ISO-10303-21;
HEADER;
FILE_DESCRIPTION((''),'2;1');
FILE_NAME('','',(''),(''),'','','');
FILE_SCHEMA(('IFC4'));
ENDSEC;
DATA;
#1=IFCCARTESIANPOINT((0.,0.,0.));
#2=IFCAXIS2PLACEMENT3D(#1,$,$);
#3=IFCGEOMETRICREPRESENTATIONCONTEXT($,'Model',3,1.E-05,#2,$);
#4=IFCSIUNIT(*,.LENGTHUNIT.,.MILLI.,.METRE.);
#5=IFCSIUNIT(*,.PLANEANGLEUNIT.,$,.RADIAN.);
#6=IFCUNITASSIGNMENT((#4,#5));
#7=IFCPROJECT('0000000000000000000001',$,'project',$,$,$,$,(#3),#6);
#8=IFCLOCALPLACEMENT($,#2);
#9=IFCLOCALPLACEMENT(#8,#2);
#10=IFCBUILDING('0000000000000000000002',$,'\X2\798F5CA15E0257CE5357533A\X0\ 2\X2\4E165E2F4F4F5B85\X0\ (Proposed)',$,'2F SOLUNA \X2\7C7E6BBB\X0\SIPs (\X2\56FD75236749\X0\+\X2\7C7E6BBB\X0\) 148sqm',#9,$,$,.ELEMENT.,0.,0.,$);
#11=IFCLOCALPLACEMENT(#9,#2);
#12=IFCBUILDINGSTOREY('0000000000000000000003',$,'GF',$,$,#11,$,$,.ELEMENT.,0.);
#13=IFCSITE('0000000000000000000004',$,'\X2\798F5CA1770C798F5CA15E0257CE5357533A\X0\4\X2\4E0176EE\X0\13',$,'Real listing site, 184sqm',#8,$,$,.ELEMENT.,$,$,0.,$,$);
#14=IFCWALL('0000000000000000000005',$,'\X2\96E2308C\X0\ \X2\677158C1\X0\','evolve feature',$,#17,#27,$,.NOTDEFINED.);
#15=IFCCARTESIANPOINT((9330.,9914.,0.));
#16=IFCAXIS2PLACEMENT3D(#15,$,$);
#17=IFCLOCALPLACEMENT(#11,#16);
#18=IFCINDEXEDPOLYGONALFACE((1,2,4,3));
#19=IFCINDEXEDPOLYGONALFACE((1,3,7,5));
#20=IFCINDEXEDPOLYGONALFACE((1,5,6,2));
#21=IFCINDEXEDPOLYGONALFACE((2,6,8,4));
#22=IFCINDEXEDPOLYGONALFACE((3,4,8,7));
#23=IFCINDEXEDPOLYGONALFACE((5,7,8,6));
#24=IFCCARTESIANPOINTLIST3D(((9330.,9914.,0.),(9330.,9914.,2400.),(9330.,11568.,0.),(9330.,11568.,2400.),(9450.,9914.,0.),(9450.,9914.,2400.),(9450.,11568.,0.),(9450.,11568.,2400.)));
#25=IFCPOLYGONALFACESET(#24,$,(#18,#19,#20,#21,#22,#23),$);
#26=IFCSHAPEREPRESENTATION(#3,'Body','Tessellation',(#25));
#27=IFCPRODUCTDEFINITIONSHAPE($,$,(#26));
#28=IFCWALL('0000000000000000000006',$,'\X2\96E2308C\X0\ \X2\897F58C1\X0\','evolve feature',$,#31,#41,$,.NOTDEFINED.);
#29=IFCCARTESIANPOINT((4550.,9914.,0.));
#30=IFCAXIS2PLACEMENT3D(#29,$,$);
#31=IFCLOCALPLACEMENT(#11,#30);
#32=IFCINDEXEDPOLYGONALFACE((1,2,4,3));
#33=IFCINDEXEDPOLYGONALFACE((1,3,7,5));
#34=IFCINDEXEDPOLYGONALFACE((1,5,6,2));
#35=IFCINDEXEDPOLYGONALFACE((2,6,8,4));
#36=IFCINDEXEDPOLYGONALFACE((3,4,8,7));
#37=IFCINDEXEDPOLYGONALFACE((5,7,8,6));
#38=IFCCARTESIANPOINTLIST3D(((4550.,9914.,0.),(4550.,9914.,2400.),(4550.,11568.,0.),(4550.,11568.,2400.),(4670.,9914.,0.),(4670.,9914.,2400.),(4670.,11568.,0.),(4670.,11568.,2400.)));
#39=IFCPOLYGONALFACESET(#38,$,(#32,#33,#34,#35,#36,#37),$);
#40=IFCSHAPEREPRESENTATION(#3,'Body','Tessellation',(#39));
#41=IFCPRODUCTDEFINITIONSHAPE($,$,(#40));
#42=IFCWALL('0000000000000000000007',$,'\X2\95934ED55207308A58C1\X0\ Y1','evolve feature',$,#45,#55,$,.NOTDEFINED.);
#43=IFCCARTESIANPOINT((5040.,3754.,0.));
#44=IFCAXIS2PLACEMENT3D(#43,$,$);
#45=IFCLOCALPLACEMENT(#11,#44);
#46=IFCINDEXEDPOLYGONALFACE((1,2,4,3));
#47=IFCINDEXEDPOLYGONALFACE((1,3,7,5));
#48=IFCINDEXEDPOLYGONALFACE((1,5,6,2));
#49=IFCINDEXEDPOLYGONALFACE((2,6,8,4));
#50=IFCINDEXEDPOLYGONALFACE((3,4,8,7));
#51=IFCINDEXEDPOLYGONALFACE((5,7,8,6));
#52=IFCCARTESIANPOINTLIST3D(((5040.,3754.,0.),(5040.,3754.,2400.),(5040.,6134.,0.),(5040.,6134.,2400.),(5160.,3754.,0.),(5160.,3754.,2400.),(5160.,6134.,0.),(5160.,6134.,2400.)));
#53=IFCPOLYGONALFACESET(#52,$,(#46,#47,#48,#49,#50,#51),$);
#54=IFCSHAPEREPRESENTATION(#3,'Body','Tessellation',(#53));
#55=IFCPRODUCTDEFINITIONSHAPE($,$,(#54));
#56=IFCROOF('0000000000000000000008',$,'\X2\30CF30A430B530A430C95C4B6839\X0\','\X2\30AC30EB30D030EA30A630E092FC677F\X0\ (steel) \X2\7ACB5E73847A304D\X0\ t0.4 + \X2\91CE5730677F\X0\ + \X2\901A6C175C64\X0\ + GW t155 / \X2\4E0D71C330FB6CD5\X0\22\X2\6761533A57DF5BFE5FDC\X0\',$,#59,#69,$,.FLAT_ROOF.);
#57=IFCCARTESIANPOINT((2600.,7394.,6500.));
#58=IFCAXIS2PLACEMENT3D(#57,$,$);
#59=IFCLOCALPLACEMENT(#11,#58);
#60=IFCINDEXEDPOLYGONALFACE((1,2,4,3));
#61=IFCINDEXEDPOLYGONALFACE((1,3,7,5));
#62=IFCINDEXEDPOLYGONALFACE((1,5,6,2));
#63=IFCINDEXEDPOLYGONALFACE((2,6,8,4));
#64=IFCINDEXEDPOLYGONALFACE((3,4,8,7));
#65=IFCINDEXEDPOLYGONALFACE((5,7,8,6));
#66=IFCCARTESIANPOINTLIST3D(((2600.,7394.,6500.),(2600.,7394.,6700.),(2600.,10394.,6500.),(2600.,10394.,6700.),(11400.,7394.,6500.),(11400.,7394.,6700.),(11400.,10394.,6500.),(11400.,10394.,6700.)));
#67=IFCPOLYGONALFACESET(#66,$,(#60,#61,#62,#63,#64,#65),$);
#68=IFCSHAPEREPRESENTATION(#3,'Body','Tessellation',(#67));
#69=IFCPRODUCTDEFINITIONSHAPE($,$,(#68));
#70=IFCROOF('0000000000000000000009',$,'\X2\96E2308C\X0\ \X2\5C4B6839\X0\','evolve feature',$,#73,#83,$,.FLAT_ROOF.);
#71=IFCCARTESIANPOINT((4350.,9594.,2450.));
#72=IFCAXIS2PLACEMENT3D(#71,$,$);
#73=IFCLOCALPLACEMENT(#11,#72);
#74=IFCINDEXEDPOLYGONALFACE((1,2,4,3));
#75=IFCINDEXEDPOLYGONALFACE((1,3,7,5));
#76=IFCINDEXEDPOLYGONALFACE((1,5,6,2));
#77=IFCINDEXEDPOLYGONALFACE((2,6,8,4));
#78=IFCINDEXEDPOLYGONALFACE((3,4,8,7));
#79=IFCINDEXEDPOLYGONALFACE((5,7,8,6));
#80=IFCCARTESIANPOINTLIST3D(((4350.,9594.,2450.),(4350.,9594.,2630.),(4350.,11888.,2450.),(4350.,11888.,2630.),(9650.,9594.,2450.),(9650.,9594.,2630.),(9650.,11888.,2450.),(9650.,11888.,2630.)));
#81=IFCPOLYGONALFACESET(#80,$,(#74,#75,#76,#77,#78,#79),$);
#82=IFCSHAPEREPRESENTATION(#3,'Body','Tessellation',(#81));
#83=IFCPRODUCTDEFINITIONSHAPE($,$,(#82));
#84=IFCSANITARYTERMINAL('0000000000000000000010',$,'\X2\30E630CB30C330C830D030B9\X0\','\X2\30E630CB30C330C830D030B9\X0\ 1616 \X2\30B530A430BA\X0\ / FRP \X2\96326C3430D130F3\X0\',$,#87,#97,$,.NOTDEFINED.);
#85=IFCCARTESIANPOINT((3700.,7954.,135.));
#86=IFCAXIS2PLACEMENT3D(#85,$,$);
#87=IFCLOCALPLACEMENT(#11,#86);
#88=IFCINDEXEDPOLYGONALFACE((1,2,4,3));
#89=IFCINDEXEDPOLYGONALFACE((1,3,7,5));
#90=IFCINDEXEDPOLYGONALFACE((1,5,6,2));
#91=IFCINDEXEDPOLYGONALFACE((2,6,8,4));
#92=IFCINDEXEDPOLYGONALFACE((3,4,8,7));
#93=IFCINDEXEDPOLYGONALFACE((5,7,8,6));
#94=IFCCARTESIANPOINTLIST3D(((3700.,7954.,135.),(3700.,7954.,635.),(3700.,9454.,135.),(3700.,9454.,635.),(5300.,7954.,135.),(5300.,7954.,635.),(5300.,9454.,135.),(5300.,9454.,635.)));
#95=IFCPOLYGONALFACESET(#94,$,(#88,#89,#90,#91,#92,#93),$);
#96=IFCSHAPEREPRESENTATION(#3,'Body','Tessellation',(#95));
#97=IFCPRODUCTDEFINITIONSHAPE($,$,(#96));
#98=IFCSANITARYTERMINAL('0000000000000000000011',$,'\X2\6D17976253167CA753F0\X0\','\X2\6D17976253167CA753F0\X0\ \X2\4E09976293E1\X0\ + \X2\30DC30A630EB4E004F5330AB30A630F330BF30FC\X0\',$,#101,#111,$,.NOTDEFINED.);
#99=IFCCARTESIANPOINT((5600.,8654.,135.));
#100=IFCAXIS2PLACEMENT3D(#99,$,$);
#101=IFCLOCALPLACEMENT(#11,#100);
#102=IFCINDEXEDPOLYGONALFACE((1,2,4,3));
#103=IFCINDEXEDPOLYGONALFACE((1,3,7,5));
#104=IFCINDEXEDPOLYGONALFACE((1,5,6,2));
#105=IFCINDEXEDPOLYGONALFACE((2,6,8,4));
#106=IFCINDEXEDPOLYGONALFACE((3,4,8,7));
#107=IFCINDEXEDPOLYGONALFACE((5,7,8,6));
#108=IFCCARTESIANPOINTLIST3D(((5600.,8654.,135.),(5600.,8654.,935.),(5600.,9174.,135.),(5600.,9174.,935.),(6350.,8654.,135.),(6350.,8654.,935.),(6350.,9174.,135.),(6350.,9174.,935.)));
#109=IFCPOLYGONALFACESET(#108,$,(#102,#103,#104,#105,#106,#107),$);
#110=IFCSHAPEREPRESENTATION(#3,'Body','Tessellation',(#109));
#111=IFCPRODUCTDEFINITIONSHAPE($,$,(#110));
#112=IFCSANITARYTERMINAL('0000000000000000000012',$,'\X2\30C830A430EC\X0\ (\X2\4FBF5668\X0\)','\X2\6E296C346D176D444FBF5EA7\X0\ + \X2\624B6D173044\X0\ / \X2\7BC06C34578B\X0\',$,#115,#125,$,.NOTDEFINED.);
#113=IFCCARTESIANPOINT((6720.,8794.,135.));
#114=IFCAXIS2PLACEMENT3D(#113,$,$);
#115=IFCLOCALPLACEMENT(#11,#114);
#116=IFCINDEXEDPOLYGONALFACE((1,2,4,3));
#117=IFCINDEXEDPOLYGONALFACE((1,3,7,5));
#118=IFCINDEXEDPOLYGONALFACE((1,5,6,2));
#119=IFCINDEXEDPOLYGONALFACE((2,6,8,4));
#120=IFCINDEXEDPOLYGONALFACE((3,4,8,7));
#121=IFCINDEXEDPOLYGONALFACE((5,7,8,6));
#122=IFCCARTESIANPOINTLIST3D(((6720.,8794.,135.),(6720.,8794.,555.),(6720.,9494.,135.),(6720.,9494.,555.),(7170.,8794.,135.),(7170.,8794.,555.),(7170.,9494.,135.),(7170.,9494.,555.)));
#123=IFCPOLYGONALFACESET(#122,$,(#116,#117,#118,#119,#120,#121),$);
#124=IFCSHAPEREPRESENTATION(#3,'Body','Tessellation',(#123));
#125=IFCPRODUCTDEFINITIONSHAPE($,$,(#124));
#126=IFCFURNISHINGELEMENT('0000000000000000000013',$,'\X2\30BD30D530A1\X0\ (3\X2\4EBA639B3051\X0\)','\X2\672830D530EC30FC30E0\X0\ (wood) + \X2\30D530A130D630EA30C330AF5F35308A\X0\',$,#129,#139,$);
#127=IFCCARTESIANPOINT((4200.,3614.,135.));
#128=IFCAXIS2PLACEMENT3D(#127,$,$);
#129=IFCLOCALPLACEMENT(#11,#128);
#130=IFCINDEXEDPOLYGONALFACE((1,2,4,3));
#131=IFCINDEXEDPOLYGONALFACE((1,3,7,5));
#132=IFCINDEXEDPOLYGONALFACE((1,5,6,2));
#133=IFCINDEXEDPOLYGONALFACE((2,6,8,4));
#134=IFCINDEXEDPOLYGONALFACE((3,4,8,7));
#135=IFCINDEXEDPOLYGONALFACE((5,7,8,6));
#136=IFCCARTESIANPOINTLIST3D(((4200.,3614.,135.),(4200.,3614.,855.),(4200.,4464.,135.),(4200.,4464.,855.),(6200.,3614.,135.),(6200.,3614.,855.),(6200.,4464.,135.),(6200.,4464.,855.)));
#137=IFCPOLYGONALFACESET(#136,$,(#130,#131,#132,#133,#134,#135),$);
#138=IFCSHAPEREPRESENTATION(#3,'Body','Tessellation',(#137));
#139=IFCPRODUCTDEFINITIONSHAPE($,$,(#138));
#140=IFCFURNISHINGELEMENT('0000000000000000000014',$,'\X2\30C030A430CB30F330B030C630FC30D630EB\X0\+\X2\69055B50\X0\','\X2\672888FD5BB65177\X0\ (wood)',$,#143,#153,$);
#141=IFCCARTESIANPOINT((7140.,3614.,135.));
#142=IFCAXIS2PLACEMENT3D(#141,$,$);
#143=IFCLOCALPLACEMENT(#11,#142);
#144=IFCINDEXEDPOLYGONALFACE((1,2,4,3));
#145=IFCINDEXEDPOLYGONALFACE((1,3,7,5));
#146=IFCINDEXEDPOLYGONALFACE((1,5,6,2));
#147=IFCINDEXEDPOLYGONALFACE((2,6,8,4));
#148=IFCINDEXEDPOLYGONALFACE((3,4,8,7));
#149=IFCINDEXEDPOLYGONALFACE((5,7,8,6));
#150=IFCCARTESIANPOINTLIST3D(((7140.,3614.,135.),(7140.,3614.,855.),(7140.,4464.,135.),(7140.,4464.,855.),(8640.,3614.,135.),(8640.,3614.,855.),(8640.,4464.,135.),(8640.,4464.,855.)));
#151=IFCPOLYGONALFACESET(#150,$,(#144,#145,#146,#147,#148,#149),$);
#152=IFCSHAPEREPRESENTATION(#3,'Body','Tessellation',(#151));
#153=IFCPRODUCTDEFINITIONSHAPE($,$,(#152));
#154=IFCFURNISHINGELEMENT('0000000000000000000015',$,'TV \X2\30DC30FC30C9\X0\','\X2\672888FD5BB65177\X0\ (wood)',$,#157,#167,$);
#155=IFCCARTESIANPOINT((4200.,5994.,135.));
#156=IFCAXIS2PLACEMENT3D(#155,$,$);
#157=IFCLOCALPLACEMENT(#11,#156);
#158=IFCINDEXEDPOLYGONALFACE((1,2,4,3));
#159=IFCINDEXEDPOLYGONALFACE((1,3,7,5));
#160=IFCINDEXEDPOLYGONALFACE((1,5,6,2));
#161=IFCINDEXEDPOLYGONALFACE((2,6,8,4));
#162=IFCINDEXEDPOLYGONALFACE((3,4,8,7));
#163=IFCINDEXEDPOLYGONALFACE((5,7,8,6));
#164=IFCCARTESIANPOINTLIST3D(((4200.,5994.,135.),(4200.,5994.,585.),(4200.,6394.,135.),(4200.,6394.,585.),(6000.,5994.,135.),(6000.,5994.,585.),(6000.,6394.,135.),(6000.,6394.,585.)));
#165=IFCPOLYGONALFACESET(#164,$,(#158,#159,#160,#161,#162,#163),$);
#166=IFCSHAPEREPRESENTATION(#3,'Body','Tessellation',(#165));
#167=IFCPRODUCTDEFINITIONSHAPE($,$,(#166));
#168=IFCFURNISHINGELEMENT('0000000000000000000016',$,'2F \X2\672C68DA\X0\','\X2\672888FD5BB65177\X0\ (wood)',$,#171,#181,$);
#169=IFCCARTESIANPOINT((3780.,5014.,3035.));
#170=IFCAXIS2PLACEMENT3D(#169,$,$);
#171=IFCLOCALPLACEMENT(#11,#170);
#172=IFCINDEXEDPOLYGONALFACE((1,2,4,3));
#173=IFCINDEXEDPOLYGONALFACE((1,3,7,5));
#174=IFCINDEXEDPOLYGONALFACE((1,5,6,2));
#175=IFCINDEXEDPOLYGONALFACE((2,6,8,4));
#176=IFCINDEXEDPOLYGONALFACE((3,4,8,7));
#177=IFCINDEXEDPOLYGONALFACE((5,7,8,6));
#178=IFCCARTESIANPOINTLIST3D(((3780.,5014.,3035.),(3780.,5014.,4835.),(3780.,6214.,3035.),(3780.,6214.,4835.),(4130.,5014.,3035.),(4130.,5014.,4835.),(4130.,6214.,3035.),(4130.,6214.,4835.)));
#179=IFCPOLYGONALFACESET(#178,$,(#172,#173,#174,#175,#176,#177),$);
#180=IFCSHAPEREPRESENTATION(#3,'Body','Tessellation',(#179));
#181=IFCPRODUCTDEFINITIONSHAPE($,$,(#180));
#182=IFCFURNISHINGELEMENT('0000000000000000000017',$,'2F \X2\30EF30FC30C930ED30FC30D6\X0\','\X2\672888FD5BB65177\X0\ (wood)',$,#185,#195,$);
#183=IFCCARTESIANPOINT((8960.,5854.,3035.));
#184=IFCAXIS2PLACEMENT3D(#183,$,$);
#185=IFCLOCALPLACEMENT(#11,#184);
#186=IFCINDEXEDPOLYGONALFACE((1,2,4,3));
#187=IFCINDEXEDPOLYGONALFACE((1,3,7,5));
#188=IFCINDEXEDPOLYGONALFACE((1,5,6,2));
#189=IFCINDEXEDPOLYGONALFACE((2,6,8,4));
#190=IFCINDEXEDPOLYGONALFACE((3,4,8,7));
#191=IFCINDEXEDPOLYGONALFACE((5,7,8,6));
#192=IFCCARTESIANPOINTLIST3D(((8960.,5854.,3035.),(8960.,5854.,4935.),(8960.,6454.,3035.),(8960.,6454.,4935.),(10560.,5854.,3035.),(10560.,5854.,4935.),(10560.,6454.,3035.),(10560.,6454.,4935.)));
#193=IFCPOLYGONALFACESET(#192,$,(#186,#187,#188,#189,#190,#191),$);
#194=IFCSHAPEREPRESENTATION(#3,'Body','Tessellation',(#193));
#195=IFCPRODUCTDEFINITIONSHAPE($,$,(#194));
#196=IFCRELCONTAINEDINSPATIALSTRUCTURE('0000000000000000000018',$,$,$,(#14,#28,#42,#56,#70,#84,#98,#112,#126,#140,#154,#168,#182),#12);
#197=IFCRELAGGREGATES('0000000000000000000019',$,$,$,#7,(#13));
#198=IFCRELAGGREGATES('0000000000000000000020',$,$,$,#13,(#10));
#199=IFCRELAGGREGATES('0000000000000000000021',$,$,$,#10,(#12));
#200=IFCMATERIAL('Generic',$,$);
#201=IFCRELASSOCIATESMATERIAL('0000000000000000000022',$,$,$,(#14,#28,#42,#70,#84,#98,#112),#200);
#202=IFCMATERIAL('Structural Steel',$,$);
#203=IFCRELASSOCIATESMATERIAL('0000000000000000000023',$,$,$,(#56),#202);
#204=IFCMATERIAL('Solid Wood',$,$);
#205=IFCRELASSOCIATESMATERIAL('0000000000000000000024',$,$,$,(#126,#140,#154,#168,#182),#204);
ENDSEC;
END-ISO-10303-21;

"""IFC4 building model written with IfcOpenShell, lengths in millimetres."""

from ifc_helpers import new_model, si_unit, frame, frame_2d, origin, place, context, project, spatial, rectangle, extrude, material, element, save


model = new_model("IFC4")

# Units and contexts
model_context = context("Model", 3, precision=1e-05, world=origin())
ifc_project = project(units=[si_unit("LENGTHUNIT", "METRE", prefix="MILLI"), si_unit("PLANEANGLEUNIT", "RADIAN")], contexts=[model_context])

# Site, building, storey
site_placement = place(None, origin())
site = spatial("IfcSite", under=ifc_project, at=site_placement, Name="福岡県福岡市城南区4丁目13", ObjectType="Real listing site, 184sqm", CompositionType="ELEMENT", RefElevation=0.0)
building_placement = place(site_placement, origin())
building = spatial("IfcBuilding", under=site, at=building_placement, Name="福岡市城南区 2世帯住宅 (Proposed)", ObjectType="2F SOLUNA 籾殻SIPs (国産杉+籾殻) 148sqm", CompositionType="ELEMENT", ElevationOfRefHeight=0.0, ElevationOfTerrain=0.0)
storey_placement = place(building_placement, origin())
storey = spatial("IfcBuildingStorey", under=building, at=storey_placement, Name="GF", CompositionType="ELEMENT", Elevation=0.0)

# Shared definitions
ifc_material_1 = material(Name="Generic")

# Shared definitions
ifc_material_2 = material(Name="Solid Wood")

# Walls
wall_1_placement = place(storey_placement, frame((9330.0, 9914.0, 0.0)))
element("IfcWall", 1, at=wall_1_placement, inside=storey, material=ifc_material_1, Name="離れ 東壁", Description="evolve feature", PredefinedType="NOTDEFINED", context=model_context, shape_type="SweptSolid", body=[
    extrude(rectangle(XDim=120.0, YDim=1654.0, at=frame_2d((60.0, 827.0))), frame((9330.0, 9914.0, 0.0)), (0.0, 0.0, 1.0), 2400.0),
])
wall_2_placement = place(storey_placement, frame((4550.0, 9914.0, 0.0)))
element("IfcWall", 2, at=wall_2_placement, inside=storey, material=ifc_material_1, Name="離れ 西壁", Description="evolve feature", PredefinedType="NOTDEFINED", context=model_context, shape_type="SweptSolid", body=[
    extrude(rectangle(XDim=120.0, YDim=1654.0, at=frame_2d((60.0, 827.0))), frame((4550.0, 9914.0, 0.0)), (0.0, 0.0, 1.0), 2400.0),
])
wall_3_placement = place(storey_placement, frame((5040.0, 3754.0, 0.0)))
element("IfcWall", 3, at=wall_3_placement, inside=storey, material=ifc_material_1, Name="間仕切り壁 Y1", Description="evolve feature", PredefinedType="NOTDEFINED", context=model_context, shape_type="SweptSolid", body=[
    extrude(rectangle(XDim=120.0, YDim=2380.0, at=frame_2d((60.0, 1190.0))), frame((5040.0, 3754.0, 0.0)), (0.0, 0.0, 1.0), 2400.0),
])

# Roofs
ifc_material_3 = material(Name="Structural Steel")
roof_1_placement = place(storey_placement, frame((2600.0, 7394.0, 6500.0)))
element("IfcRoof", 4, at=roof_1_placement, inside=storey, material=ifc_material_3, Name="ハイサイド屋根", Description="ガルバリウム鋼板 (steel) 立平葺き t0.4 + 野地板 + 通気層 + GW t155 / 不燃・法22条区域対応", PredefinedType="FLAT_ROOF", context=model_context, shape_type="SweptSolid", body=[
    extrude(rectangle(XDim=8800.0, YDim=3000.0, at=frame_2d((4400.0, 1500.0))), frame((2600.0, 7394.0, 6500.0)), (0.0, 0.0, 1.0), 200.0),
])
roof_2_placement = place(storey_placement, frame((4350.0, 9594.0, 2450.0)))
element("IfcRoof", 5, at=roof_2_placement, inside=storey, material=ifc_material_1, Name="離れ 屋根", Description="evolve feature", PredefinedType="FLAT_ROOF", context=model_context, shape_type="SweptSolid", body=[
    extrude(rectangle(XDim=5300.0, YDim=2294.0, at=frame_2d((2650.0, 1147.0))), frame((4350.0, 9594.0, 2450.0)), (0.0, 0.0, 1.0), 180.0),
])

# Sanitary terminals
sanitary_terminal_1_placement = place(storey_placement, frame((3700.0, 7954.0, 135.0)))
element("IfcSanitaryTerminal", 6, at=sanitary_terminal_1_placement, inside=storey, material=ifc_material_1, Name="ユニットバス", Description="ユニットバス 1616 サイズ / FRP 防水パン", PredefinedType="NOTDEFINED", context=model_context, shape_type="SweptSolid", body=[
    extrude(rectangle(XDim=1600.0, YDim=1500.0, at=frame_2d((800.0, 750.0))), frame((3700.0, 7954.0, 135.0)), (0.0, 0.0, 1.0), 500.0),
])
sanitary_terminal_2_placement = place(storey_placement, frame((5600.0, 8654.0, 135.0)))
element("IfcSanitaryTerminal", 7, at=sanitary_terminal_2_placement, inside=storey, material=ifc_material_1, Name="洗面化粧台", Description="洗面化粧台 三面鏡 + ボウル一体カウンター", PredefinedType="NOTDEFINED", context=model_context, shape_type="SweptSolid", body=[
    extrude(rectangle(XDim=750.0, YDim=520.0, at=frame_2d((375.0, 260.0))), frame((5600.0, 8654.0, 135.0)), (0.0, 0.0, 1.0), 800.0),
])
sanitary_terminal_3_placement = place(storey_placement, frame((6720.0, 8794.0, 135.0)))
element("IfcSanitaryTerminal", 8, at=sanitary_terminal_3_placement, inside=storey, material=ifc_material_1, Name="トイレ (便器)", Description="温水洗浄便座 + 手洗い / 節水型", PredefinedType="NOTDEFINED", context=model_context, shape_type="SweptSolid", body=[
    extrude(rectangle(XDim=450.0, YDim=700.0, at=frame_2d((225.0, 350.0))), frame((6720.0, 8794.0, 135.0)), (0.0, 0.0, 1.0), 420.0),
])

# Furnishing elements
furnishing_1_placement = place(storey_placement, frame((4200.0, 3614.0, 135.0)))
element("IfcFurnishingElement", 9, at=furnishing_1_placement, inside=storey, material=ifc_material_2, Name="ソファ (3人掛け)", Description="木フレーム (wood) + ファブリック張り", context=model_context, shape_type="SweptSolid", body=[
    extrude(rectangle(XDim=2000.0, YDim=850.0, at=frame_2d((1000.0, 425.0))), frame((4200.0, 3614.0, 135.0)), (0.0, 0.0, 1.0), 720.0),
])
furnishing_2_placement = place(storey_placement, frame((7140.0, 3614.0, 135.0)))
element("IfcFurnishingElement", 10, at=furnishing_2_placement, inside=storey, material=ifc_material_2, Name="ダイニングテーブル+椅子", Description="木製家具 (wood)", context=model_context, shape_type="SweptSolid", body=[
    extrude(rectangle(XDim=1500.0, YDim=850.0, at=frame_2d((750.0, 425.0))), frame((7140.0, 3614.0, 135.0)), (0.0, 0.0, 1.0), 720.0),
])
furnishing_3_placement = place(storey_placement, frame((4200.0, 5994.0, 135.0)))
element("IfcFurnishingElement", 11, at=furnishing_3_placement, inside=storey, material=ifc_material_2, Name="TV ボード", Description="木製家具 (wood)", context=model_context, shape_type="SweptSolid", body=[
    extrude(rectangle(XDim=1800.0, YDim=400.0, at=frame_2d((900.0, 200.0))), frame((4200.0, 5994.0, 135.0)), (0.0, 0.0, 1.0), 450.0),
])
furnishing_4_placement = place(storey_placement, frame((3780.0, 5014.0, 3035.0)))
element("IfcFurnishingElement", 12, at=furnishing_4_placement, inside=storey, material=ifc_material_2, Name="2F 本棚", Description="木製家具 (wood)", context=model_context, shape_type="SweptSolid", body=[
    extrude(rectangle(XDim=350.0, YDim=1200.0, at=frame_2d((175.0, 600.0))), frame((3780.0, 5014.0, 3035.0)), (0.0, 0.0, 1.0), 1800.0),
])
furnishing_5_placement = place(storey_placement, frame((8960.0, 5854.0, 3035.0)))
element("IfcFurnishingElement", 13, at=furnishing_5_placement, inside=storey, material=ifc_material_2, Name="2F ワードローブ", Description="木製家具 (wood)", context=model_context, shape_type="SweptSolid", body=[
    extrude(rectangle(XDim=1600.0, YDim=600.0, at=frame_2d((800.0, 300.0))), frame((8960.0, 5854.0, 3035.0)), (0.0, 0.0, 1.0), 1900.0),
])

save(model, "model.ifc")
